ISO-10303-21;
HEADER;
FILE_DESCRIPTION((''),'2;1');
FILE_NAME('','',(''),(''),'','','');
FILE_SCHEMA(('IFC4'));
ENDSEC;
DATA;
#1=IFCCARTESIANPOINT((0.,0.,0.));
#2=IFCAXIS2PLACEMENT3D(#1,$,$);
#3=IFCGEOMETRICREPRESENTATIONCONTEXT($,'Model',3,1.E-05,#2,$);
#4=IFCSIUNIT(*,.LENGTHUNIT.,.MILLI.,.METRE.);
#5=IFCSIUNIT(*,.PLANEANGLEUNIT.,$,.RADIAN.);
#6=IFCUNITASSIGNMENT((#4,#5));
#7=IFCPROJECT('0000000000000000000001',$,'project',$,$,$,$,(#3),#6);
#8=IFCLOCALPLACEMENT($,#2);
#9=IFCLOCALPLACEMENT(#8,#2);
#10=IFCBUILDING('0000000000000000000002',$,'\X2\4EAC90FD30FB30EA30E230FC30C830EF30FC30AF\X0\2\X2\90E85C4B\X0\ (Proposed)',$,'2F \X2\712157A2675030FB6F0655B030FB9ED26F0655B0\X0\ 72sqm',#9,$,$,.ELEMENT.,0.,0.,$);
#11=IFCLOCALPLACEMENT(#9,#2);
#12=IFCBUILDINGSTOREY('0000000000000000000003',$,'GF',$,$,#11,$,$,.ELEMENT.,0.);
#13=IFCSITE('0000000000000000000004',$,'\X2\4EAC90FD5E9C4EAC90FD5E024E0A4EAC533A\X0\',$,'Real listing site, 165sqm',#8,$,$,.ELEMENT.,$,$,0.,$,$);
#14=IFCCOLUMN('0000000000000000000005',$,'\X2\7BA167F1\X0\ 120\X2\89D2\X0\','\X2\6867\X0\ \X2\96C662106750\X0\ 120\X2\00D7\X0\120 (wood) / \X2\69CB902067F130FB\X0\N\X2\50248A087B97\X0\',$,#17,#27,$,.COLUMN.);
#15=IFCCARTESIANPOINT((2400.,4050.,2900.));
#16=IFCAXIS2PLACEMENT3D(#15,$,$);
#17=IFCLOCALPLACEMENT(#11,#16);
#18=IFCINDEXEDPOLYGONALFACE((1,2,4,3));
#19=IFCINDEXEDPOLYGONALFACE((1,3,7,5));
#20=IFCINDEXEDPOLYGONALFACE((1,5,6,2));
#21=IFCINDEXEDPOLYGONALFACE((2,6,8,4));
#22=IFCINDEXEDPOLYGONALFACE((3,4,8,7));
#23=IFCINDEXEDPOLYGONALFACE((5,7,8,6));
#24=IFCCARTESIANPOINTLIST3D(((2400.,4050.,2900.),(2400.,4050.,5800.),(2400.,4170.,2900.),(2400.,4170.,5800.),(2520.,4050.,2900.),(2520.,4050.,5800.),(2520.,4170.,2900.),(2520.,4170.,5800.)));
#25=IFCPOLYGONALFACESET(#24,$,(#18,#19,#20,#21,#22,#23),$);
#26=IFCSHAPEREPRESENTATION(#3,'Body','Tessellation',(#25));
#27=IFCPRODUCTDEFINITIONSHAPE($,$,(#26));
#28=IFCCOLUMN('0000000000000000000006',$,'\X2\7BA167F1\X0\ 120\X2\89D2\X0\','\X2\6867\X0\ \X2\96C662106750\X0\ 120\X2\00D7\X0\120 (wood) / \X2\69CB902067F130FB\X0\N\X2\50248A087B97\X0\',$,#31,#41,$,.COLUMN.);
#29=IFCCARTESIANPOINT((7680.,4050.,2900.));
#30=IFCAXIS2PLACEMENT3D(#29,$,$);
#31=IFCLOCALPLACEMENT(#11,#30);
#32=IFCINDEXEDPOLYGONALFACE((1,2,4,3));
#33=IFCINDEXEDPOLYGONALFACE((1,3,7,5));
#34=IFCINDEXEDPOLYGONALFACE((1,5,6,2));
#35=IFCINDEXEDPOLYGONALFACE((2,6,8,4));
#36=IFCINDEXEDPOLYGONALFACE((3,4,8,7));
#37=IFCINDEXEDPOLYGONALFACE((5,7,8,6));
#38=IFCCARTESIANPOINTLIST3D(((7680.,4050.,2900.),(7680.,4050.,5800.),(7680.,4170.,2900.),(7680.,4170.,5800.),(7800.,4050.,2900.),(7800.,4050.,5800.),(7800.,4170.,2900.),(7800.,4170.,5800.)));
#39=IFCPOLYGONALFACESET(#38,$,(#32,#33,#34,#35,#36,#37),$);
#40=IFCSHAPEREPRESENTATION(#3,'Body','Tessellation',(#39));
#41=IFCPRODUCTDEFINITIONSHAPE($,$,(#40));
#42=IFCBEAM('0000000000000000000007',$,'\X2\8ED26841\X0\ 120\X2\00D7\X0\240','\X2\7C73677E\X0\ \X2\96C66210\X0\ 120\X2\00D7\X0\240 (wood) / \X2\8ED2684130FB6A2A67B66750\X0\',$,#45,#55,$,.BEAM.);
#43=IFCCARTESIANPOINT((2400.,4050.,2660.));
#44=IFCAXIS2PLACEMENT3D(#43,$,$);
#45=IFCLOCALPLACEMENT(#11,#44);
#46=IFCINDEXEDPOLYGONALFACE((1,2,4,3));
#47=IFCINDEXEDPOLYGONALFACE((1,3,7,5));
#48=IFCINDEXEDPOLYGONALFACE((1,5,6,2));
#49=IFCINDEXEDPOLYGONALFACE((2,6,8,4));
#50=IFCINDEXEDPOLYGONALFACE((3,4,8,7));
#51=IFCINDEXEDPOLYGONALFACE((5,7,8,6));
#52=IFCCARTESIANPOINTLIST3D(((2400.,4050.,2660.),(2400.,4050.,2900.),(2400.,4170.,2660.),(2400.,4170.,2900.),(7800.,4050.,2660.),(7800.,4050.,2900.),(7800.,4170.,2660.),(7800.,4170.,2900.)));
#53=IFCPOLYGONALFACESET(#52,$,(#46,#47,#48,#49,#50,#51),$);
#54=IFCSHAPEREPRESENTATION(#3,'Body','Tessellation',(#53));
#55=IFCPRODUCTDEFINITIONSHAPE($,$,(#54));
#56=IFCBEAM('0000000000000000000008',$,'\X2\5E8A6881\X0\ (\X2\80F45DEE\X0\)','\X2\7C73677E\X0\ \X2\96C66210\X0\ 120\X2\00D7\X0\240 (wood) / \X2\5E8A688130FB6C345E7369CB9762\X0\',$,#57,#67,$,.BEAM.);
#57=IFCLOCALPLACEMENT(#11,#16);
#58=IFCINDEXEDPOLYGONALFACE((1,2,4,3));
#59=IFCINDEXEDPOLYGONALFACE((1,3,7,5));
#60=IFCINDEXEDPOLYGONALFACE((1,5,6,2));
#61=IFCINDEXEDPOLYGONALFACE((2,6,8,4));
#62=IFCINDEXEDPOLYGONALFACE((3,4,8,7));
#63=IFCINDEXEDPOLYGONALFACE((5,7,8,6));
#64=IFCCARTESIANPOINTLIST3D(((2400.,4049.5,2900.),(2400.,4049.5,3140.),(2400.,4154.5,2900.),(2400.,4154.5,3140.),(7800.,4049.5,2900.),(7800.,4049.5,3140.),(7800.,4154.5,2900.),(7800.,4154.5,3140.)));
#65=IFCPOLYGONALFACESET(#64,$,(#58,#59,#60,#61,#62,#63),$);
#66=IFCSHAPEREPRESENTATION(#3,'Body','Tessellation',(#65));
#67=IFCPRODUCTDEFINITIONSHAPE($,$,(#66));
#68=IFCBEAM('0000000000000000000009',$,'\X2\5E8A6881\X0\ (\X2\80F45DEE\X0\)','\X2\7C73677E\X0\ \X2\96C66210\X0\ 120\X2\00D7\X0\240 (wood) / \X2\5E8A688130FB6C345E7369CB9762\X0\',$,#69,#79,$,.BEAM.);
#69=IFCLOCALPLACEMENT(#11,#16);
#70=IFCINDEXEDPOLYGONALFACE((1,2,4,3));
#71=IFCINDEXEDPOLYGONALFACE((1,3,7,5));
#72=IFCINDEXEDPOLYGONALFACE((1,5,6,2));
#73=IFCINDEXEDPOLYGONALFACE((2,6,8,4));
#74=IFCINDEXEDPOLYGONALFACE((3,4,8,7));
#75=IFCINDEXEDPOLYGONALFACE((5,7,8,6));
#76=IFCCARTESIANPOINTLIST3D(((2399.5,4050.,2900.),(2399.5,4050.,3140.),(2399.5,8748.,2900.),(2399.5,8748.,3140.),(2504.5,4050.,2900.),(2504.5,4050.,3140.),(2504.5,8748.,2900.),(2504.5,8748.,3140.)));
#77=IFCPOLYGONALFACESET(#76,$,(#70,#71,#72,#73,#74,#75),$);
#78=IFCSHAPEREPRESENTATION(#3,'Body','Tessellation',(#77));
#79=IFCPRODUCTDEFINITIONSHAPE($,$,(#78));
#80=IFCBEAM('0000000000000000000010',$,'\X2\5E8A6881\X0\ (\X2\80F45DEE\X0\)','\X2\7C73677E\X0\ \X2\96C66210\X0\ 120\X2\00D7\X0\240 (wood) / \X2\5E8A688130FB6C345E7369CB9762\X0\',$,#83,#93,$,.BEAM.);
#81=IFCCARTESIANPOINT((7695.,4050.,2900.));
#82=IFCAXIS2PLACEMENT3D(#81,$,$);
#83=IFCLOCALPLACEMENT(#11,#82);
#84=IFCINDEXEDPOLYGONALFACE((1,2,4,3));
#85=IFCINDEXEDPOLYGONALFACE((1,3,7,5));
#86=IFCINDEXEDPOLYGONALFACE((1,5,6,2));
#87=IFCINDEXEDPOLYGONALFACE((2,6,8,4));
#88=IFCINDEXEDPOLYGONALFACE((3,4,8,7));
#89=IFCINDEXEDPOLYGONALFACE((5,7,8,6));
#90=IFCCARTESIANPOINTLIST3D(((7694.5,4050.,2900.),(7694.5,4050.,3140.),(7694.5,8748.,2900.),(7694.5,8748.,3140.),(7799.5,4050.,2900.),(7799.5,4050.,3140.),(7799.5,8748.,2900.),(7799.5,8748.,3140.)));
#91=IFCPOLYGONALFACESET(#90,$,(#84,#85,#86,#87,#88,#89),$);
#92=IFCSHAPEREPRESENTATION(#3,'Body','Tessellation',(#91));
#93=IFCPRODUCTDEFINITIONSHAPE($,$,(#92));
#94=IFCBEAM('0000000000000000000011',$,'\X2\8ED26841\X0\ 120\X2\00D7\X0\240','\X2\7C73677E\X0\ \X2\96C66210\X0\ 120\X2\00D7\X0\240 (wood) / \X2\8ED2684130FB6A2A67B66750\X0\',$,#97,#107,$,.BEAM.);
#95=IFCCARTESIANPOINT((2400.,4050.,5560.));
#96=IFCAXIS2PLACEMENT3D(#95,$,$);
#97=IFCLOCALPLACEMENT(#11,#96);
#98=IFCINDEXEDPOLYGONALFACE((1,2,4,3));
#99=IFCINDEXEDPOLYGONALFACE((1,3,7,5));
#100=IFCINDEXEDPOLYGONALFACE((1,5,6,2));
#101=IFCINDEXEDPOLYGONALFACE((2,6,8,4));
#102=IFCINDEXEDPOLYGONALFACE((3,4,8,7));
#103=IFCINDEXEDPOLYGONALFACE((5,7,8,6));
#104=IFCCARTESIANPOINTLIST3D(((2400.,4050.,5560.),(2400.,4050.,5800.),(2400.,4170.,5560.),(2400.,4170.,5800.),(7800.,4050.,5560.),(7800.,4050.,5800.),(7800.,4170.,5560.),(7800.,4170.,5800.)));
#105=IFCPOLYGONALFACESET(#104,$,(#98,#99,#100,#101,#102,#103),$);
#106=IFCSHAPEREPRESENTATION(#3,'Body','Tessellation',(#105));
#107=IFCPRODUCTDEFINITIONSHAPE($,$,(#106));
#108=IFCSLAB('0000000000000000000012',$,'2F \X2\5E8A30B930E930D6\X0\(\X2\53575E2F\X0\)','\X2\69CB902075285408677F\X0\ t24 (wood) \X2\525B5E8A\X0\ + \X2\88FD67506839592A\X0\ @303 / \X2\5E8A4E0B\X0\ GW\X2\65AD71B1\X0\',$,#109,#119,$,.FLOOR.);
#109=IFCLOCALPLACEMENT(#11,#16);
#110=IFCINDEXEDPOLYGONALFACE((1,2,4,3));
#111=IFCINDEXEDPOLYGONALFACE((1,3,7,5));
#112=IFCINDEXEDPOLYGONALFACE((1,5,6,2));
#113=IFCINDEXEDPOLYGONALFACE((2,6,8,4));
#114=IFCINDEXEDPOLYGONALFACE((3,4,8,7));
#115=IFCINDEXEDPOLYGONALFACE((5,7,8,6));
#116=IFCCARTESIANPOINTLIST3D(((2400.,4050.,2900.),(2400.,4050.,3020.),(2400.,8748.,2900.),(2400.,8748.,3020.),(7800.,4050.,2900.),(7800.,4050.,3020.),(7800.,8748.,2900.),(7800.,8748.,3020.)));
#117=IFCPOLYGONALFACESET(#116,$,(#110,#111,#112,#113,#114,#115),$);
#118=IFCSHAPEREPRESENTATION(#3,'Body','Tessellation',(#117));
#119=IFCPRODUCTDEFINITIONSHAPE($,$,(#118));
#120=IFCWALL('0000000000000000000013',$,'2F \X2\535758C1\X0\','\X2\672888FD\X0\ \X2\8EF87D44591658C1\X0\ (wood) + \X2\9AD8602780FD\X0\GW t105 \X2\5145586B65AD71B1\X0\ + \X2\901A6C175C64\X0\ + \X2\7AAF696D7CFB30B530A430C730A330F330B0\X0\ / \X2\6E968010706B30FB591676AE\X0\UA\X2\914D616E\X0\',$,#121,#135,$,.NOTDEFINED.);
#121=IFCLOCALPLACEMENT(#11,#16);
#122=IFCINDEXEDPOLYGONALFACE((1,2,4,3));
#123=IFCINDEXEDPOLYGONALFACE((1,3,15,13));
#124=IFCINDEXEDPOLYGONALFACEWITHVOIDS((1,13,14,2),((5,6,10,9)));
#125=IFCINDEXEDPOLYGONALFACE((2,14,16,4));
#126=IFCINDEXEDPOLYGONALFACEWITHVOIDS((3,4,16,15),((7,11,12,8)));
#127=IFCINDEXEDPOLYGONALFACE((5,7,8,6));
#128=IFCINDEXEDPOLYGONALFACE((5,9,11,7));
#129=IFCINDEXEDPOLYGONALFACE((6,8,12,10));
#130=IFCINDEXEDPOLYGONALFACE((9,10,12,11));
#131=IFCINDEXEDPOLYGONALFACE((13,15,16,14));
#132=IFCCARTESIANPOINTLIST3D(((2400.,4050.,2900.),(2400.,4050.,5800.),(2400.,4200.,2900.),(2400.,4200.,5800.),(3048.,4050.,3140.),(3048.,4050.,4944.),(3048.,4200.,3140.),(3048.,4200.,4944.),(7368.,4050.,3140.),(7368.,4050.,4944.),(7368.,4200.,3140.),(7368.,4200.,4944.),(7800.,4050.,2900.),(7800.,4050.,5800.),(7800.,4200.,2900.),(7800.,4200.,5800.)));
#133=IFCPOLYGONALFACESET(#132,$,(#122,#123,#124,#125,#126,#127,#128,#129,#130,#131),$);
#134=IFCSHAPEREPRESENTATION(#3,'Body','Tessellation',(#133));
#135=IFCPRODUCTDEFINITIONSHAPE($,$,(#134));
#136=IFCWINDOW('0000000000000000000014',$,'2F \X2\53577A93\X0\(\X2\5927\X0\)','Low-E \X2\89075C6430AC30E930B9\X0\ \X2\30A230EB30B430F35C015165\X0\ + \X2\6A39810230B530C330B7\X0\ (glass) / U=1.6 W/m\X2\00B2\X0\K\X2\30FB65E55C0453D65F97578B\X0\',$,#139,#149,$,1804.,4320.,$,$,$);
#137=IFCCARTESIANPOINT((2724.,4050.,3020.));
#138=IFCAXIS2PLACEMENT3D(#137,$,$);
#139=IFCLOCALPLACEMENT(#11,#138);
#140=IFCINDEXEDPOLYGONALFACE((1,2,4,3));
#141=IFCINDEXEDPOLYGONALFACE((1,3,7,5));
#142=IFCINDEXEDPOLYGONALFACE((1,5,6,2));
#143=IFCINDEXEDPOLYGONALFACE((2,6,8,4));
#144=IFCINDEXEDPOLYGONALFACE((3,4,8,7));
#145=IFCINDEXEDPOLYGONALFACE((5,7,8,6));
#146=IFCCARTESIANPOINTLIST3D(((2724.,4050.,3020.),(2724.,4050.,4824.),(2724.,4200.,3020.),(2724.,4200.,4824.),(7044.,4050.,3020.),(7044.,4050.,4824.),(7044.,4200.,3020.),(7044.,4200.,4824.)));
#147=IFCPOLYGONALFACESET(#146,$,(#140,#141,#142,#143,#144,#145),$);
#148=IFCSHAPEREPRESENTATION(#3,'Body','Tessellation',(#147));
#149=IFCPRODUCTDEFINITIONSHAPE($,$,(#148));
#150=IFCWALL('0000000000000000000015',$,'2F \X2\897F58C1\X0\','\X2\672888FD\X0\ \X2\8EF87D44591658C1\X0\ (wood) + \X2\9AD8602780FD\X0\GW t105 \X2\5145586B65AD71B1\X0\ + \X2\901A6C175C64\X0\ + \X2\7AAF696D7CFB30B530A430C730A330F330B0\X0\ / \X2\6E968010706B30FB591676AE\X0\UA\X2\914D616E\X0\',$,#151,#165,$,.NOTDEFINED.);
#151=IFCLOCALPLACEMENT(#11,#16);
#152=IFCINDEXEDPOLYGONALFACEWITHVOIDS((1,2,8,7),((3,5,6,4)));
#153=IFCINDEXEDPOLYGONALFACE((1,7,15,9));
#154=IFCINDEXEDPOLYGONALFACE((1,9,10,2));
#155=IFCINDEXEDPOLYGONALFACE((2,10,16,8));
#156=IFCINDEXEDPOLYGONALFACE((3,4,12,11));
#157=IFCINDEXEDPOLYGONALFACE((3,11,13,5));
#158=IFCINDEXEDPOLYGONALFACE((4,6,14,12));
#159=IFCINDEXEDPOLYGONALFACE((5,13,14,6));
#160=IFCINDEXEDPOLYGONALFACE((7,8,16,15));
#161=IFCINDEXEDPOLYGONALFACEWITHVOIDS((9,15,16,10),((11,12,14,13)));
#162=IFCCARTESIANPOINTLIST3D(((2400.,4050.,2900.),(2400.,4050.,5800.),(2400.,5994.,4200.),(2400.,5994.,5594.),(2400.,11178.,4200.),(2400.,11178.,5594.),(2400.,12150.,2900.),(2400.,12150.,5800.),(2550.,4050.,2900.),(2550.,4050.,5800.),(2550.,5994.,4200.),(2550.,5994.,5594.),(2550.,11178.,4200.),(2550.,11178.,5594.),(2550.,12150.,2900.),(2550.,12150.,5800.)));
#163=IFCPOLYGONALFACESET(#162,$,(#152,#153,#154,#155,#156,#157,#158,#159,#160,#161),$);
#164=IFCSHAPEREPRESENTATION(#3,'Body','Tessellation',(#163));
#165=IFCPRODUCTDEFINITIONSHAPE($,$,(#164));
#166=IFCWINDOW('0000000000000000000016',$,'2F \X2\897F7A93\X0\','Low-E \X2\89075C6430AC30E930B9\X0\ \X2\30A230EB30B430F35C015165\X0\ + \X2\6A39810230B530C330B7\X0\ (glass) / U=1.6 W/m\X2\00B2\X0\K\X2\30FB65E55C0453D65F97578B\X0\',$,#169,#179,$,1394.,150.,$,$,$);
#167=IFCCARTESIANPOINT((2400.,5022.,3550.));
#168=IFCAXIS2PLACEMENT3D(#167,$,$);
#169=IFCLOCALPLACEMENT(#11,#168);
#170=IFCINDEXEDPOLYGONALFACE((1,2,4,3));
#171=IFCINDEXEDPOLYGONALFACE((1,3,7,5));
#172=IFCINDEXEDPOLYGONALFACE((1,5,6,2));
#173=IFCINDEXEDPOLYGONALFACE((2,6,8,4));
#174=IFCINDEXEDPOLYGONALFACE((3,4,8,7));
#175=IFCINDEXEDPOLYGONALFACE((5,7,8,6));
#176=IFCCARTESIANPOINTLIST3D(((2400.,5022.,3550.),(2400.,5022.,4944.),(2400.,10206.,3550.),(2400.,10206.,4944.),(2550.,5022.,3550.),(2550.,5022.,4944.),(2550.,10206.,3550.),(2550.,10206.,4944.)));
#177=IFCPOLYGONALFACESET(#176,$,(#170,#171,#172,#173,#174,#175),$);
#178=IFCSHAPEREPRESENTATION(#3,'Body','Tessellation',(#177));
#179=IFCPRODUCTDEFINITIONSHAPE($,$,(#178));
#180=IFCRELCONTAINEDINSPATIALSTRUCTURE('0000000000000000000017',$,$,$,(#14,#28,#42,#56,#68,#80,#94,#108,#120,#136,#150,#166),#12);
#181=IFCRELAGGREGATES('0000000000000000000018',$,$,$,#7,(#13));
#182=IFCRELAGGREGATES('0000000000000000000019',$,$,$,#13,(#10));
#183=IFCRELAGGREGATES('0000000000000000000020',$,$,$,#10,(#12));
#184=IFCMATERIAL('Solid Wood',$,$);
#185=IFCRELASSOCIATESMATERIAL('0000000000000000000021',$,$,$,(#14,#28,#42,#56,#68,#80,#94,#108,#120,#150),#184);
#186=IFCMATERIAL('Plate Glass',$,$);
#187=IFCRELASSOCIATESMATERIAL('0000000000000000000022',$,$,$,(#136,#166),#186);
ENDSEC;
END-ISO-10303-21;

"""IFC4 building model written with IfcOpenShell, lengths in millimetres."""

from ifc_helpers import new_model, si_unit, frame, frame_2d, origin, place, context, project, spatial, rectangle, extrude, material, element, fill, save


model = new_model("IFC4")

# Units and contexts
model_context = context("Model", 3, precision=1e-05, world=origin())
ifc_project = project(units=[si_unit("LENGTHUNIT", "METRE", prefix="MILLI"), si_unit("PLANEANGLEUNIT", "RADIAN")], contexts=[model_context])

# Site, building, storey
site_placement = place(None, origin())
site = spatial("IfcSite", under=ifc_project, at=site_placement, Name="京都府京都市上京区", ObjectType="Real listing site, 165sqm", CompositionType="ELEMENT", RefElevation=0.0)
building_placement = place(site_placement, origin())
building = spatial("IfcBuilding", under=site, at=building_placement, Name="京都・リモートワーク2部屋 (Proposed)", ObjectType="2F 無垢材・漆喰・黒漆喰 72sqm", CompositionType="ELEMENT", ElevationOfRefHeight=0.0, ElevationOfTerrain=0.0)
storey_placement = place(building_placement, origin())
storey = spatial("IfcBuildingStorey", under=building, at=storey_placement, Name="GF", CompositionType="ELEMENT", Elevation=0.0)

# Columns
ifc_material_1 = material(Name="Solid Wood")
column_1_placement = place(storey_placement, frame((2400.0, 4050.0, 2900.0)))
element("IfcColumn", 1, at=column_1_placement, inside=storey, material=ifc_material_1, Name="管柱 120角", Description="桧 集成材 120×120 (wood) / 構造柱・N値計算", PredefinedType="COLUMN", context=model_context, shape_type="SweptSolid", body=[
    extrude(rectangle(XDim=120.0, YDim=120.0, at=frame_2d((60.0, 60.0))), frame((2400.0, 4050.0, 2900.0)), (0.0, 0.0, 1.0), 2900.0),
])
column_2_placement = place(storey_placement, frame((7680.0, 4050.0, 2900.0)))
element("IfcColumn", 2, at=column_2_placement, inside=storey, material=ifc_material_1, Name="管柱 120角", Description="桧 集成材 120×120 (wood) / 構造柱・N値計算", PredefinedType="COLUMN", context=model_context, shape_type="SweptSolid", body=[
    extrude(rectangle(XDim=120.0, YDim=120.0, at=frame_2d((60.0, 60.0))), frame((7680.0, 4050.0, 2900.0)), (0.0, 0.0, 1.0), 2900.0),
])

# Beams
beam_1_placement = place(storey_placement, frame((2400.0, 4050.0, 2660.0)))
element("IfcBeam", 3, at=beam_1_placement, inside=storey, material=ifc_material_1, Name="軒桁 120×240", Description="米松 集成 120×240 (wood) / 軒桁・横架材", PredefinedType="BEAM", context=model_context, shape_type="SweptSolid", body=[
    extrude(rectangle(XDim=5400.0, YDim=120.0, at=frame_2d((2700.0, 60.0))), frame((2400.0, 4050.0, 2660.0)), (0.0, 0.0, 1.0), 240.0),
])
beam_2_placement = place(storey_placement, frame((2400.0, 4050.0, 2900.0)))
element("IfcBeam", 4, at=beam_2_placement, inside=storey, material=ifc_material_1, Name="床梁 (胴差)", Description="米松 集成 120×240 (wood) / 床梁・水平構面", PredefinedType="BEAM", context=model_context, shape_type="SweptSolid", body=[
    extrude(rectangle(XDim=5400.0, YDim=105.0, at=frame_2d((2700.0, 52.0))), frame((2400.0, 4050.0, 2900.0)), (0.0, 0.0, 1.0), 240.0),
])
beam_3_placement = place(storey_placement, frame((2400.0, 4050.0, 2900.0)))
element("IfcBeam", 5, at=beam_3_placement, inside=storey, material=ifc_material_1, Name="床梁 (胴差)", Description="米松 集成 120×240 (wood) / 床梁・水平構面", PredefinedType="BEAM", context=model_context, shape_type="SweptSolid", body=[
    extrude(rectangle(XDim=105.0, YDim=4698.0, at=frame_2d((52.0, 2349.0))), frame((2400.0, 4050.0, 2900.0)), (0.0, 0.0, 1.0), 240.0),
])
beam_4_placement = place(storey_placement, frame((7695.0, 4050.0, 2900.0)))
element("IfcBeam", 6, at=beam_4_placement, inside=storey, material=ifc_material_1, Name="床梁 (胴差)", Description="米松 集成 120×240 (wood) / 床梁・水平構面", PredefinedType="BEAM", context=model_context, shape_type="SweptSolid", body=[
    extrude(rectangle(XDim=105.0, YDim=4698.0, at=frame_2d((52.0, 2349.0))), frame((7695.0, 4050.0, 2900.0)), (0.0, 0.0, 1.0), 240.0),
])
beam_5_placement = place(storey_placement, frame((2400.0, 4050.0, 5560.0)))
element("IfcBeam", 7, at=beam_5_placement, inside=storey, material=ifc_material_1, Name="軒桁 120×240", Description="米松 集成 120×240 (wood) / 軒桁・横架材", PredefinedType="BEAM", context=model_context, shape_type="SweptSolid", body=[
    extrude(rectangle(XDim=5400.0, YDim=120.0, at=frame_2d((2700.0, 60.0))), frame((2400.0, 4050.0, 5560.0)), (0.0, 0.0, 1.0), 240.0),
])

# Slab
slab_placement = place(storey_placement, frame((2400.0, 4050.0, 2900.0)))
element("IfcSlab", 8, at=slab_placement, inside=storey, material=ifc_material_1, Name="2F 床スラブ(南帯)", Description="構造用合板 t24 (wood) 剛床 + 製材根太 @303 / 床下 GW断熱", PredefinedType="FLOOR", context=model_context, shape_type="SweptSolid", body=[
    extrude(rectangle(XDim=5400.0, YDim=4698.0, at=frame_2d((2700.0, 2349.0))), frame((2400.0, 4050.0, 2900.0)), (0.0, 0.0, 1.0), 120.0),
])

# Walls, openings, windows
wall_1_placement = place(storey_placement, frame((2400.0, 4050.0, 2900.0)))
wall_1 = element("IfcWall", 9, at=wall_1_placement, inside=storey, material=ifc_material_1, Name="2F 南壁", Description="木製 軸組外壁 (wood) + 高性能GW t105 充填断熱 + 通気層 + 窯業系サイディング / 準耐火・外皮UA配慮", PredefinedType="NOTDEFINED", context=model_context, shape_type="SweptSolid", body=[
    extrude(rectangle(XDim=5400.0, YDim=150.0, at=frame_2d((2700.0, 75.0))), frame((2400.0, 4050.0, 2900.0)), (0.0, 0.0, 1.0), 2900.0),
])
opening_1_placement = place(storey_placement, frame((2724.0, 4050.0, 3020.0)))
opening_1 = element("IfcOpeningElement", 10, at=opening_1_placement, cuts=wall_1, PredefinedType="NOTDEFINED", context=model_context, shape_type="SweptSolid", body=[
    extrude(rectangle(XDim=4320.0, YDim=150.0, at=frame_2d((2160.0, 75.0))), frame((2724.0, 4050.0, 3020.0)), (0.0, 0.0, 1.0), 1804.0),
])
ifc_material_2 = material(Name="Plate Glass")
window_1_placement = place(storey_placement, frame((2724.0, 4050.0, 3020.0)))
window_1 = element("IfcWindow", 11, at=window_1_placement, inside=storey, material=ifc_material_2, Name="2F 南窓(大)", Description="Low-E 複層ガラス アルゴン封入 + 樹脂サッシ (glass) / U=1.6 W/m²K・日射取得型", OverallHeight=1804.0, OverallWidth=4320.0, context=model_context, shape_type="SweptSolid", body=[
    extrude(rectangle(XDim=4320.0, YDim=150.0, at=frame_2d((2160.0, 75.0))), frame((2724.0, 4050.0, 3020.0)), (0.0, 0.0, 1.0), 1804.0),
])
fill(opening_1, window_1)
wall_2_placement = place(storey_placement, frame((2400.0, 4050.0, 2900.0)))
wall_2 = element("IfcWall", 12, at=wall_2_placement, inside=storey, material=ifc_material_1, Name="2F 西壁", Description="木製 軸組外壁 (wood) + 高性能GW t105 充填断熱 + 通気層 + 窯業系サイディング / 準耐火・外皮UA配慮", PredefinedType="NOTDEFINED", context=model_context, shape_type="SweptSolid", body=[
    extrude(rectangle(XDim=150.0, YDim=8100.0, at=frame_2d((75.0, 4050.0))), frame((2400.0, 4050.0, 2900.0)), (0.0, 0.0, 1.0), 2900.0),
])
opening_2_placement = place(storey_placement, frame((2400.0, 5022.0, 3550.0)))
opening_2 = element("IfcOpeningElement", 13, at=opening_2_placement, cuts=wall_2, PredefinedType="NOTDEFINED", context=model_context, shape_type="SweptSolid", body=[
    extrude(rectangle(XDim=150.0, YDim=5184.0, at=frame_2d((75.0, 2592.0))), frame((2400.0, 5022.0, 3550.0)), (0.0, 0.0, 1.0), 1394.0),
])
window_2_placement = place(storey_placement, frame((2400.0, 5022.0, 3550.0)))
window_2 = element("IfcWindow", 14, at=window_2_placement, inside=storey, material=ifc_material_2, Name="2F 西窓", Description="Low-E 複層ガラス アルゴン封入 + 樹脂サッシ (glass) / U=1.6 W/m²K・日射取得型", OverallHeight=1394.0, OverallWidth=150.0, context=model_context, shape_type="SweptSolid", body=[
    extrude(rectangle(XDim=150.0, YDim=5184.0, at=frame_2d((75.0, 2592.0))), frame((2400.0, 5022.0, 3550.0)), (0.0, 0.0, 1.0), 1394.0),
])
fill(opening_2, window_2)

save(model, "model.ifc")
